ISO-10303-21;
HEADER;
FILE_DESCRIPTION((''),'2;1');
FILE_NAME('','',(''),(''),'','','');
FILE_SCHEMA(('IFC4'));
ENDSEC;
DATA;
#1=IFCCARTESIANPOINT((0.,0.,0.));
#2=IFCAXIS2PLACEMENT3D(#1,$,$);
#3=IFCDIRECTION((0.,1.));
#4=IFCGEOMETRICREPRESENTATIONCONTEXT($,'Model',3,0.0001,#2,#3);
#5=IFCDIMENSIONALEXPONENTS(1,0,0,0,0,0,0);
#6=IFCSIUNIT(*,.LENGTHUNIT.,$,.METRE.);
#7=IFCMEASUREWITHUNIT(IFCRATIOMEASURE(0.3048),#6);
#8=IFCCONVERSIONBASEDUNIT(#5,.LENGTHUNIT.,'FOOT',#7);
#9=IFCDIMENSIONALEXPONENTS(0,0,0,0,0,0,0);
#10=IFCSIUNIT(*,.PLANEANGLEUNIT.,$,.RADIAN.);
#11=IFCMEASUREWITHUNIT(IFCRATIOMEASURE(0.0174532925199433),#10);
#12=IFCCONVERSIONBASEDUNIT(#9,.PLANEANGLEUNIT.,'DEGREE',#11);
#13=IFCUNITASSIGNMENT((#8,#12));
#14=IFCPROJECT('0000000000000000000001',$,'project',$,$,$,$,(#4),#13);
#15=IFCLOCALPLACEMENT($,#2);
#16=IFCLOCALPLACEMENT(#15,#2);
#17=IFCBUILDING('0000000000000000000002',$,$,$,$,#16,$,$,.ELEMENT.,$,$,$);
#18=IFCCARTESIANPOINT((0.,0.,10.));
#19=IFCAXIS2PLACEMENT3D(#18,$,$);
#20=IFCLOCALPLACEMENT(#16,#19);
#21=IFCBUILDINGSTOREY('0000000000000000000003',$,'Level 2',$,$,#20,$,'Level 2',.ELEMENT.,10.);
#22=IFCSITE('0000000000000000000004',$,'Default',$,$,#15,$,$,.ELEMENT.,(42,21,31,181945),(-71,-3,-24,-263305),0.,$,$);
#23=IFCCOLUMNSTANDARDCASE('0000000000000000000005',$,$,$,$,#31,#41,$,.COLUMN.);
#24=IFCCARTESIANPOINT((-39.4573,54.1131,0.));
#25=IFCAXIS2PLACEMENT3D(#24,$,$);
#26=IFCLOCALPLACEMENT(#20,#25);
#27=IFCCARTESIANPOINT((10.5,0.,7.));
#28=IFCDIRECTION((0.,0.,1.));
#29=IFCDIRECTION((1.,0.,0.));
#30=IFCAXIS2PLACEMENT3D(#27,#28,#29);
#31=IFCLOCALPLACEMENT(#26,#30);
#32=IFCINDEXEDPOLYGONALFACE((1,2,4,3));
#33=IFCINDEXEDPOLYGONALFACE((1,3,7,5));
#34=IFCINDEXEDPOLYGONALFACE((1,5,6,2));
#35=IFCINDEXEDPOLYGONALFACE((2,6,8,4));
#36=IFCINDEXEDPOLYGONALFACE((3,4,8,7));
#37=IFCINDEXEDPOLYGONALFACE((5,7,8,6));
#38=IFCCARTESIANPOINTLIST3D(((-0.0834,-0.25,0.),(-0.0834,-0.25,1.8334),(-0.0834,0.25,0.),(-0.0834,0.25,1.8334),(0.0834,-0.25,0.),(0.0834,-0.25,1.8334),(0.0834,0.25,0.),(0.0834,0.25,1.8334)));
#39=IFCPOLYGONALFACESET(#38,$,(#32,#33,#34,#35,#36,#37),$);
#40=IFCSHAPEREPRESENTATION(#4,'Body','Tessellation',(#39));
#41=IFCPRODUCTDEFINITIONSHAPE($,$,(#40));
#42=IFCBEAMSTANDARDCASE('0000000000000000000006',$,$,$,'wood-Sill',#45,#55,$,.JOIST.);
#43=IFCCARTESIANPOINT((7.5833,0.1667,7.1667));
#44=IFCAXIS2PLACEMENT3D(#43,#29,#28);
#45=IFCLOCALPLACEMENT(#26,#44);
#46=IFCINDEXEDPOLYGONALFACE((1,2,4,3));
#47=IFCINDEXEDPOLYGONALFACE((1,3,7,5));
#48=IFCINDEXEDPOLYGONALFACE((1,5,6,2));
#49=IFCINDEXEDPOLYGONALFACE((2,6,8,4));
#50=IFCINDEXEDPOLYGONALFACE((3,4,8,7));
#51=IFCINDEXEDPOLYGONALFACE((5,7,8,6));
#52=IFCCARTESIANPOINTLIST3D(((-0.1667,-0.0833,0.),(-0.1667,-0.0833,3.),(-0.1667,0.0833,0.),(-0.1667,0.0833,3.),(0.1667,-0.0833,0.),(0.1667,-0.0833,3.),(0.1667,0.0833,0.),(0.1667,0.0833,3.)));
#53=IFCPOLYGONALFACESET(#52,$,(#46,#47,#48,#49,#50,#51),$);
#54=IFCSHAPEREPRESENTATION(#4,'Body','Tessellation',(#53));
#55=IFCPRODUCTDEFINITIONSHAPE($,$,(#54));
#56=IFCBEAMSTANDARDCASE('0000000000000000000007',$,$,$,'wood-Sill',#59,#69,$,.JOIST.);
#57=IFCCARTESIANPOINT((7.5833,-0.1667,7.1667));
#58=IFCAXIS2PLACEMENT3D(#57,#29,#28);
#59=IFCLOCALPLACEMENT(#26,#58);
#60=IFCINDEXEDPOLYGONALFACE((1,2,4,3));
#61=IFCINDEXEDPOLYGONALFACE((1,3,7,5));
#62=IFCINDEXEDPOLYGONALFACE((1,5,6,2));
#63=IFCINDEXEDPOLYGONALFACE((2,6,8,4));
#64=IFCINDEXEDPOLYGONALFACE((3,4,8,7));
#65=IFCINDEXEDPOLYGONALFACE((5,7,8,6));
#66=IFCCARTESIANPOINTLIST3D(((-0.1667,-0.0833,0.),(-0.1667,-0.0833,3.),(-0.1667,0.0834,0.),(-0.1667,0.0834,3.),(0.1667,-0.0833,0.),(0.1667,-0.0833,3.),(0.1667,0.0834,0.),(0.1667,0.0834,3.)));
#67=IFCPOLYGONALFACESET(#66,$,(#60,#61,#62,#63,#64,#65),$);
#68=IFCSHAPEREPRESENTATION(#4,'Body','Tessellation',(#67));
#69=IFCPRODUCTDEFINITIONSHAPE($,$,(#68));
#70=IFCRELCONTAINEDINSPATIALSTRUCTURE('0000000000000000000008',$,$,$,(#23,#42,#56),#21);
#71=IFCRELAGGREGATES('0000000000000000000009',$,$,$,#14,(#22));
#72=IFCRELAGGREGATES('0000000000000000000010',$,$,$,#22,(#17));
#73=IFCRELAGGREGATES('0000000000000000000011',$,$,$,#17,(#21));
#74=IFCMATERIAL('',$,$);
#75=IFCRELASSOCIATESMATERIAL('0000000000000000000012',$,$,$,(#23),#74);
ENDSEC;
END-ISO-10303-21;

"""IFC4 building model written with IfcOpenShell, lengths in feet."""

from ifc_helpers import new_model, entity, si_unit, converted_unit, direction, frame, origin, origin_with_axes, place, context, project, spatial, rectangle, extrude, material, element, save


model = new_model("IFC4")

# Units and contexts
model_context = context("Model", 3, precision=0.0001, world=origin(), true_north=direction((0.0, 1.0)))
ifc_project = project(units=[converted_unit("LENGTHUNIT", "FOOT", entity("IfcRatioMeasure", 0.3048), si_unit("LENGTHUNIT", "METRE"), dimensions=[1, 0, 0, 0, 0, 0, 0]), converted_unit("PLANEANGLEUNIT", "DEGREE", entity("IfcRatioMeasure", 0.0174532925199433), si_unit("PLANEANGLEUNIT", "RADIAN"), dimensions=[0, 0, 0, 0, 0, 0, 0])], contexts=[model_context])

# Site, building, storey
site_placement = place(None, origin())
site = spatial("IfcSite", under=ifc_project, at=site_placement, Name="Default", CompositionType="ELEMENT", RefLatitude=(42, 21, 31, 181945), RefLongitude=(-71, -3, -24, -263305), RefElevation=0.0)
building_placement = place(site_placement, origin())
building = spatial("IfcBuilding", under=site, at=building_placement, CompositionType="ELEMENT")
storey_placement = place(building_placement, frame((0.0, 0.0, 10.0)))
storey = spatial("IfcBuildingStorey", under=building, at=storey_placement, Name="Level 2", LongName="Level 2", CompositionType="ELEMENT", Elevation=10.0)

# Column
placement_1 = place(storey_placement, frame((-39.4573, 54.1131, 0.0)))
ifc_material_1 = material(Name="")
for number, where, z_axis, x_axis in (
    (1, (10.5, 0.0, 7.0), (0.0, 0.0, 1.0), (1.0, 0.0, 0.0)),
):
    element("IfcColumnStandardCase", number, at=place(placement_1, frame(where, z_axis=z_axis, x_axis=x_axis)), inside=storey, material=ifc_material_1, PredefinedType="COLUMN", context=model_context, shape_type="SweptSolid", body=[
        extrude(rectangle(XDim=0.1667, YDim=0.5), origin(), (0.0, 0.0, 1.0), 1.8334),
    ])

# Beams
for number, where, z_axis, x_axis in (
    (2, (7.5833, 0.1667, 7.1667), (1.0, 0.0, 0.0), (0.0, 0.0, 1.0)),
    (3, (7.5833, -0.1667, 7.1667), (1.0, 0.0, 0.0), (0.0, 0.0, 1.0)),
):
    element("IfcBeamStandardCase", number, at=place(placement_1, frame(where, z_axis=z_axis, x_axis=x_axis)), inside=storey, ObjectType="wood-Sill", PredefinedType="JOIST", context=model_context, shape_type="SweptSolid", body=[
        extrude(rectangle(XDim=0.3333, YDim=0.1667), origin_with_axes(), (0.0, 0.0, 1.0), 3.0),
    ])

save(model, "model.ifc")
